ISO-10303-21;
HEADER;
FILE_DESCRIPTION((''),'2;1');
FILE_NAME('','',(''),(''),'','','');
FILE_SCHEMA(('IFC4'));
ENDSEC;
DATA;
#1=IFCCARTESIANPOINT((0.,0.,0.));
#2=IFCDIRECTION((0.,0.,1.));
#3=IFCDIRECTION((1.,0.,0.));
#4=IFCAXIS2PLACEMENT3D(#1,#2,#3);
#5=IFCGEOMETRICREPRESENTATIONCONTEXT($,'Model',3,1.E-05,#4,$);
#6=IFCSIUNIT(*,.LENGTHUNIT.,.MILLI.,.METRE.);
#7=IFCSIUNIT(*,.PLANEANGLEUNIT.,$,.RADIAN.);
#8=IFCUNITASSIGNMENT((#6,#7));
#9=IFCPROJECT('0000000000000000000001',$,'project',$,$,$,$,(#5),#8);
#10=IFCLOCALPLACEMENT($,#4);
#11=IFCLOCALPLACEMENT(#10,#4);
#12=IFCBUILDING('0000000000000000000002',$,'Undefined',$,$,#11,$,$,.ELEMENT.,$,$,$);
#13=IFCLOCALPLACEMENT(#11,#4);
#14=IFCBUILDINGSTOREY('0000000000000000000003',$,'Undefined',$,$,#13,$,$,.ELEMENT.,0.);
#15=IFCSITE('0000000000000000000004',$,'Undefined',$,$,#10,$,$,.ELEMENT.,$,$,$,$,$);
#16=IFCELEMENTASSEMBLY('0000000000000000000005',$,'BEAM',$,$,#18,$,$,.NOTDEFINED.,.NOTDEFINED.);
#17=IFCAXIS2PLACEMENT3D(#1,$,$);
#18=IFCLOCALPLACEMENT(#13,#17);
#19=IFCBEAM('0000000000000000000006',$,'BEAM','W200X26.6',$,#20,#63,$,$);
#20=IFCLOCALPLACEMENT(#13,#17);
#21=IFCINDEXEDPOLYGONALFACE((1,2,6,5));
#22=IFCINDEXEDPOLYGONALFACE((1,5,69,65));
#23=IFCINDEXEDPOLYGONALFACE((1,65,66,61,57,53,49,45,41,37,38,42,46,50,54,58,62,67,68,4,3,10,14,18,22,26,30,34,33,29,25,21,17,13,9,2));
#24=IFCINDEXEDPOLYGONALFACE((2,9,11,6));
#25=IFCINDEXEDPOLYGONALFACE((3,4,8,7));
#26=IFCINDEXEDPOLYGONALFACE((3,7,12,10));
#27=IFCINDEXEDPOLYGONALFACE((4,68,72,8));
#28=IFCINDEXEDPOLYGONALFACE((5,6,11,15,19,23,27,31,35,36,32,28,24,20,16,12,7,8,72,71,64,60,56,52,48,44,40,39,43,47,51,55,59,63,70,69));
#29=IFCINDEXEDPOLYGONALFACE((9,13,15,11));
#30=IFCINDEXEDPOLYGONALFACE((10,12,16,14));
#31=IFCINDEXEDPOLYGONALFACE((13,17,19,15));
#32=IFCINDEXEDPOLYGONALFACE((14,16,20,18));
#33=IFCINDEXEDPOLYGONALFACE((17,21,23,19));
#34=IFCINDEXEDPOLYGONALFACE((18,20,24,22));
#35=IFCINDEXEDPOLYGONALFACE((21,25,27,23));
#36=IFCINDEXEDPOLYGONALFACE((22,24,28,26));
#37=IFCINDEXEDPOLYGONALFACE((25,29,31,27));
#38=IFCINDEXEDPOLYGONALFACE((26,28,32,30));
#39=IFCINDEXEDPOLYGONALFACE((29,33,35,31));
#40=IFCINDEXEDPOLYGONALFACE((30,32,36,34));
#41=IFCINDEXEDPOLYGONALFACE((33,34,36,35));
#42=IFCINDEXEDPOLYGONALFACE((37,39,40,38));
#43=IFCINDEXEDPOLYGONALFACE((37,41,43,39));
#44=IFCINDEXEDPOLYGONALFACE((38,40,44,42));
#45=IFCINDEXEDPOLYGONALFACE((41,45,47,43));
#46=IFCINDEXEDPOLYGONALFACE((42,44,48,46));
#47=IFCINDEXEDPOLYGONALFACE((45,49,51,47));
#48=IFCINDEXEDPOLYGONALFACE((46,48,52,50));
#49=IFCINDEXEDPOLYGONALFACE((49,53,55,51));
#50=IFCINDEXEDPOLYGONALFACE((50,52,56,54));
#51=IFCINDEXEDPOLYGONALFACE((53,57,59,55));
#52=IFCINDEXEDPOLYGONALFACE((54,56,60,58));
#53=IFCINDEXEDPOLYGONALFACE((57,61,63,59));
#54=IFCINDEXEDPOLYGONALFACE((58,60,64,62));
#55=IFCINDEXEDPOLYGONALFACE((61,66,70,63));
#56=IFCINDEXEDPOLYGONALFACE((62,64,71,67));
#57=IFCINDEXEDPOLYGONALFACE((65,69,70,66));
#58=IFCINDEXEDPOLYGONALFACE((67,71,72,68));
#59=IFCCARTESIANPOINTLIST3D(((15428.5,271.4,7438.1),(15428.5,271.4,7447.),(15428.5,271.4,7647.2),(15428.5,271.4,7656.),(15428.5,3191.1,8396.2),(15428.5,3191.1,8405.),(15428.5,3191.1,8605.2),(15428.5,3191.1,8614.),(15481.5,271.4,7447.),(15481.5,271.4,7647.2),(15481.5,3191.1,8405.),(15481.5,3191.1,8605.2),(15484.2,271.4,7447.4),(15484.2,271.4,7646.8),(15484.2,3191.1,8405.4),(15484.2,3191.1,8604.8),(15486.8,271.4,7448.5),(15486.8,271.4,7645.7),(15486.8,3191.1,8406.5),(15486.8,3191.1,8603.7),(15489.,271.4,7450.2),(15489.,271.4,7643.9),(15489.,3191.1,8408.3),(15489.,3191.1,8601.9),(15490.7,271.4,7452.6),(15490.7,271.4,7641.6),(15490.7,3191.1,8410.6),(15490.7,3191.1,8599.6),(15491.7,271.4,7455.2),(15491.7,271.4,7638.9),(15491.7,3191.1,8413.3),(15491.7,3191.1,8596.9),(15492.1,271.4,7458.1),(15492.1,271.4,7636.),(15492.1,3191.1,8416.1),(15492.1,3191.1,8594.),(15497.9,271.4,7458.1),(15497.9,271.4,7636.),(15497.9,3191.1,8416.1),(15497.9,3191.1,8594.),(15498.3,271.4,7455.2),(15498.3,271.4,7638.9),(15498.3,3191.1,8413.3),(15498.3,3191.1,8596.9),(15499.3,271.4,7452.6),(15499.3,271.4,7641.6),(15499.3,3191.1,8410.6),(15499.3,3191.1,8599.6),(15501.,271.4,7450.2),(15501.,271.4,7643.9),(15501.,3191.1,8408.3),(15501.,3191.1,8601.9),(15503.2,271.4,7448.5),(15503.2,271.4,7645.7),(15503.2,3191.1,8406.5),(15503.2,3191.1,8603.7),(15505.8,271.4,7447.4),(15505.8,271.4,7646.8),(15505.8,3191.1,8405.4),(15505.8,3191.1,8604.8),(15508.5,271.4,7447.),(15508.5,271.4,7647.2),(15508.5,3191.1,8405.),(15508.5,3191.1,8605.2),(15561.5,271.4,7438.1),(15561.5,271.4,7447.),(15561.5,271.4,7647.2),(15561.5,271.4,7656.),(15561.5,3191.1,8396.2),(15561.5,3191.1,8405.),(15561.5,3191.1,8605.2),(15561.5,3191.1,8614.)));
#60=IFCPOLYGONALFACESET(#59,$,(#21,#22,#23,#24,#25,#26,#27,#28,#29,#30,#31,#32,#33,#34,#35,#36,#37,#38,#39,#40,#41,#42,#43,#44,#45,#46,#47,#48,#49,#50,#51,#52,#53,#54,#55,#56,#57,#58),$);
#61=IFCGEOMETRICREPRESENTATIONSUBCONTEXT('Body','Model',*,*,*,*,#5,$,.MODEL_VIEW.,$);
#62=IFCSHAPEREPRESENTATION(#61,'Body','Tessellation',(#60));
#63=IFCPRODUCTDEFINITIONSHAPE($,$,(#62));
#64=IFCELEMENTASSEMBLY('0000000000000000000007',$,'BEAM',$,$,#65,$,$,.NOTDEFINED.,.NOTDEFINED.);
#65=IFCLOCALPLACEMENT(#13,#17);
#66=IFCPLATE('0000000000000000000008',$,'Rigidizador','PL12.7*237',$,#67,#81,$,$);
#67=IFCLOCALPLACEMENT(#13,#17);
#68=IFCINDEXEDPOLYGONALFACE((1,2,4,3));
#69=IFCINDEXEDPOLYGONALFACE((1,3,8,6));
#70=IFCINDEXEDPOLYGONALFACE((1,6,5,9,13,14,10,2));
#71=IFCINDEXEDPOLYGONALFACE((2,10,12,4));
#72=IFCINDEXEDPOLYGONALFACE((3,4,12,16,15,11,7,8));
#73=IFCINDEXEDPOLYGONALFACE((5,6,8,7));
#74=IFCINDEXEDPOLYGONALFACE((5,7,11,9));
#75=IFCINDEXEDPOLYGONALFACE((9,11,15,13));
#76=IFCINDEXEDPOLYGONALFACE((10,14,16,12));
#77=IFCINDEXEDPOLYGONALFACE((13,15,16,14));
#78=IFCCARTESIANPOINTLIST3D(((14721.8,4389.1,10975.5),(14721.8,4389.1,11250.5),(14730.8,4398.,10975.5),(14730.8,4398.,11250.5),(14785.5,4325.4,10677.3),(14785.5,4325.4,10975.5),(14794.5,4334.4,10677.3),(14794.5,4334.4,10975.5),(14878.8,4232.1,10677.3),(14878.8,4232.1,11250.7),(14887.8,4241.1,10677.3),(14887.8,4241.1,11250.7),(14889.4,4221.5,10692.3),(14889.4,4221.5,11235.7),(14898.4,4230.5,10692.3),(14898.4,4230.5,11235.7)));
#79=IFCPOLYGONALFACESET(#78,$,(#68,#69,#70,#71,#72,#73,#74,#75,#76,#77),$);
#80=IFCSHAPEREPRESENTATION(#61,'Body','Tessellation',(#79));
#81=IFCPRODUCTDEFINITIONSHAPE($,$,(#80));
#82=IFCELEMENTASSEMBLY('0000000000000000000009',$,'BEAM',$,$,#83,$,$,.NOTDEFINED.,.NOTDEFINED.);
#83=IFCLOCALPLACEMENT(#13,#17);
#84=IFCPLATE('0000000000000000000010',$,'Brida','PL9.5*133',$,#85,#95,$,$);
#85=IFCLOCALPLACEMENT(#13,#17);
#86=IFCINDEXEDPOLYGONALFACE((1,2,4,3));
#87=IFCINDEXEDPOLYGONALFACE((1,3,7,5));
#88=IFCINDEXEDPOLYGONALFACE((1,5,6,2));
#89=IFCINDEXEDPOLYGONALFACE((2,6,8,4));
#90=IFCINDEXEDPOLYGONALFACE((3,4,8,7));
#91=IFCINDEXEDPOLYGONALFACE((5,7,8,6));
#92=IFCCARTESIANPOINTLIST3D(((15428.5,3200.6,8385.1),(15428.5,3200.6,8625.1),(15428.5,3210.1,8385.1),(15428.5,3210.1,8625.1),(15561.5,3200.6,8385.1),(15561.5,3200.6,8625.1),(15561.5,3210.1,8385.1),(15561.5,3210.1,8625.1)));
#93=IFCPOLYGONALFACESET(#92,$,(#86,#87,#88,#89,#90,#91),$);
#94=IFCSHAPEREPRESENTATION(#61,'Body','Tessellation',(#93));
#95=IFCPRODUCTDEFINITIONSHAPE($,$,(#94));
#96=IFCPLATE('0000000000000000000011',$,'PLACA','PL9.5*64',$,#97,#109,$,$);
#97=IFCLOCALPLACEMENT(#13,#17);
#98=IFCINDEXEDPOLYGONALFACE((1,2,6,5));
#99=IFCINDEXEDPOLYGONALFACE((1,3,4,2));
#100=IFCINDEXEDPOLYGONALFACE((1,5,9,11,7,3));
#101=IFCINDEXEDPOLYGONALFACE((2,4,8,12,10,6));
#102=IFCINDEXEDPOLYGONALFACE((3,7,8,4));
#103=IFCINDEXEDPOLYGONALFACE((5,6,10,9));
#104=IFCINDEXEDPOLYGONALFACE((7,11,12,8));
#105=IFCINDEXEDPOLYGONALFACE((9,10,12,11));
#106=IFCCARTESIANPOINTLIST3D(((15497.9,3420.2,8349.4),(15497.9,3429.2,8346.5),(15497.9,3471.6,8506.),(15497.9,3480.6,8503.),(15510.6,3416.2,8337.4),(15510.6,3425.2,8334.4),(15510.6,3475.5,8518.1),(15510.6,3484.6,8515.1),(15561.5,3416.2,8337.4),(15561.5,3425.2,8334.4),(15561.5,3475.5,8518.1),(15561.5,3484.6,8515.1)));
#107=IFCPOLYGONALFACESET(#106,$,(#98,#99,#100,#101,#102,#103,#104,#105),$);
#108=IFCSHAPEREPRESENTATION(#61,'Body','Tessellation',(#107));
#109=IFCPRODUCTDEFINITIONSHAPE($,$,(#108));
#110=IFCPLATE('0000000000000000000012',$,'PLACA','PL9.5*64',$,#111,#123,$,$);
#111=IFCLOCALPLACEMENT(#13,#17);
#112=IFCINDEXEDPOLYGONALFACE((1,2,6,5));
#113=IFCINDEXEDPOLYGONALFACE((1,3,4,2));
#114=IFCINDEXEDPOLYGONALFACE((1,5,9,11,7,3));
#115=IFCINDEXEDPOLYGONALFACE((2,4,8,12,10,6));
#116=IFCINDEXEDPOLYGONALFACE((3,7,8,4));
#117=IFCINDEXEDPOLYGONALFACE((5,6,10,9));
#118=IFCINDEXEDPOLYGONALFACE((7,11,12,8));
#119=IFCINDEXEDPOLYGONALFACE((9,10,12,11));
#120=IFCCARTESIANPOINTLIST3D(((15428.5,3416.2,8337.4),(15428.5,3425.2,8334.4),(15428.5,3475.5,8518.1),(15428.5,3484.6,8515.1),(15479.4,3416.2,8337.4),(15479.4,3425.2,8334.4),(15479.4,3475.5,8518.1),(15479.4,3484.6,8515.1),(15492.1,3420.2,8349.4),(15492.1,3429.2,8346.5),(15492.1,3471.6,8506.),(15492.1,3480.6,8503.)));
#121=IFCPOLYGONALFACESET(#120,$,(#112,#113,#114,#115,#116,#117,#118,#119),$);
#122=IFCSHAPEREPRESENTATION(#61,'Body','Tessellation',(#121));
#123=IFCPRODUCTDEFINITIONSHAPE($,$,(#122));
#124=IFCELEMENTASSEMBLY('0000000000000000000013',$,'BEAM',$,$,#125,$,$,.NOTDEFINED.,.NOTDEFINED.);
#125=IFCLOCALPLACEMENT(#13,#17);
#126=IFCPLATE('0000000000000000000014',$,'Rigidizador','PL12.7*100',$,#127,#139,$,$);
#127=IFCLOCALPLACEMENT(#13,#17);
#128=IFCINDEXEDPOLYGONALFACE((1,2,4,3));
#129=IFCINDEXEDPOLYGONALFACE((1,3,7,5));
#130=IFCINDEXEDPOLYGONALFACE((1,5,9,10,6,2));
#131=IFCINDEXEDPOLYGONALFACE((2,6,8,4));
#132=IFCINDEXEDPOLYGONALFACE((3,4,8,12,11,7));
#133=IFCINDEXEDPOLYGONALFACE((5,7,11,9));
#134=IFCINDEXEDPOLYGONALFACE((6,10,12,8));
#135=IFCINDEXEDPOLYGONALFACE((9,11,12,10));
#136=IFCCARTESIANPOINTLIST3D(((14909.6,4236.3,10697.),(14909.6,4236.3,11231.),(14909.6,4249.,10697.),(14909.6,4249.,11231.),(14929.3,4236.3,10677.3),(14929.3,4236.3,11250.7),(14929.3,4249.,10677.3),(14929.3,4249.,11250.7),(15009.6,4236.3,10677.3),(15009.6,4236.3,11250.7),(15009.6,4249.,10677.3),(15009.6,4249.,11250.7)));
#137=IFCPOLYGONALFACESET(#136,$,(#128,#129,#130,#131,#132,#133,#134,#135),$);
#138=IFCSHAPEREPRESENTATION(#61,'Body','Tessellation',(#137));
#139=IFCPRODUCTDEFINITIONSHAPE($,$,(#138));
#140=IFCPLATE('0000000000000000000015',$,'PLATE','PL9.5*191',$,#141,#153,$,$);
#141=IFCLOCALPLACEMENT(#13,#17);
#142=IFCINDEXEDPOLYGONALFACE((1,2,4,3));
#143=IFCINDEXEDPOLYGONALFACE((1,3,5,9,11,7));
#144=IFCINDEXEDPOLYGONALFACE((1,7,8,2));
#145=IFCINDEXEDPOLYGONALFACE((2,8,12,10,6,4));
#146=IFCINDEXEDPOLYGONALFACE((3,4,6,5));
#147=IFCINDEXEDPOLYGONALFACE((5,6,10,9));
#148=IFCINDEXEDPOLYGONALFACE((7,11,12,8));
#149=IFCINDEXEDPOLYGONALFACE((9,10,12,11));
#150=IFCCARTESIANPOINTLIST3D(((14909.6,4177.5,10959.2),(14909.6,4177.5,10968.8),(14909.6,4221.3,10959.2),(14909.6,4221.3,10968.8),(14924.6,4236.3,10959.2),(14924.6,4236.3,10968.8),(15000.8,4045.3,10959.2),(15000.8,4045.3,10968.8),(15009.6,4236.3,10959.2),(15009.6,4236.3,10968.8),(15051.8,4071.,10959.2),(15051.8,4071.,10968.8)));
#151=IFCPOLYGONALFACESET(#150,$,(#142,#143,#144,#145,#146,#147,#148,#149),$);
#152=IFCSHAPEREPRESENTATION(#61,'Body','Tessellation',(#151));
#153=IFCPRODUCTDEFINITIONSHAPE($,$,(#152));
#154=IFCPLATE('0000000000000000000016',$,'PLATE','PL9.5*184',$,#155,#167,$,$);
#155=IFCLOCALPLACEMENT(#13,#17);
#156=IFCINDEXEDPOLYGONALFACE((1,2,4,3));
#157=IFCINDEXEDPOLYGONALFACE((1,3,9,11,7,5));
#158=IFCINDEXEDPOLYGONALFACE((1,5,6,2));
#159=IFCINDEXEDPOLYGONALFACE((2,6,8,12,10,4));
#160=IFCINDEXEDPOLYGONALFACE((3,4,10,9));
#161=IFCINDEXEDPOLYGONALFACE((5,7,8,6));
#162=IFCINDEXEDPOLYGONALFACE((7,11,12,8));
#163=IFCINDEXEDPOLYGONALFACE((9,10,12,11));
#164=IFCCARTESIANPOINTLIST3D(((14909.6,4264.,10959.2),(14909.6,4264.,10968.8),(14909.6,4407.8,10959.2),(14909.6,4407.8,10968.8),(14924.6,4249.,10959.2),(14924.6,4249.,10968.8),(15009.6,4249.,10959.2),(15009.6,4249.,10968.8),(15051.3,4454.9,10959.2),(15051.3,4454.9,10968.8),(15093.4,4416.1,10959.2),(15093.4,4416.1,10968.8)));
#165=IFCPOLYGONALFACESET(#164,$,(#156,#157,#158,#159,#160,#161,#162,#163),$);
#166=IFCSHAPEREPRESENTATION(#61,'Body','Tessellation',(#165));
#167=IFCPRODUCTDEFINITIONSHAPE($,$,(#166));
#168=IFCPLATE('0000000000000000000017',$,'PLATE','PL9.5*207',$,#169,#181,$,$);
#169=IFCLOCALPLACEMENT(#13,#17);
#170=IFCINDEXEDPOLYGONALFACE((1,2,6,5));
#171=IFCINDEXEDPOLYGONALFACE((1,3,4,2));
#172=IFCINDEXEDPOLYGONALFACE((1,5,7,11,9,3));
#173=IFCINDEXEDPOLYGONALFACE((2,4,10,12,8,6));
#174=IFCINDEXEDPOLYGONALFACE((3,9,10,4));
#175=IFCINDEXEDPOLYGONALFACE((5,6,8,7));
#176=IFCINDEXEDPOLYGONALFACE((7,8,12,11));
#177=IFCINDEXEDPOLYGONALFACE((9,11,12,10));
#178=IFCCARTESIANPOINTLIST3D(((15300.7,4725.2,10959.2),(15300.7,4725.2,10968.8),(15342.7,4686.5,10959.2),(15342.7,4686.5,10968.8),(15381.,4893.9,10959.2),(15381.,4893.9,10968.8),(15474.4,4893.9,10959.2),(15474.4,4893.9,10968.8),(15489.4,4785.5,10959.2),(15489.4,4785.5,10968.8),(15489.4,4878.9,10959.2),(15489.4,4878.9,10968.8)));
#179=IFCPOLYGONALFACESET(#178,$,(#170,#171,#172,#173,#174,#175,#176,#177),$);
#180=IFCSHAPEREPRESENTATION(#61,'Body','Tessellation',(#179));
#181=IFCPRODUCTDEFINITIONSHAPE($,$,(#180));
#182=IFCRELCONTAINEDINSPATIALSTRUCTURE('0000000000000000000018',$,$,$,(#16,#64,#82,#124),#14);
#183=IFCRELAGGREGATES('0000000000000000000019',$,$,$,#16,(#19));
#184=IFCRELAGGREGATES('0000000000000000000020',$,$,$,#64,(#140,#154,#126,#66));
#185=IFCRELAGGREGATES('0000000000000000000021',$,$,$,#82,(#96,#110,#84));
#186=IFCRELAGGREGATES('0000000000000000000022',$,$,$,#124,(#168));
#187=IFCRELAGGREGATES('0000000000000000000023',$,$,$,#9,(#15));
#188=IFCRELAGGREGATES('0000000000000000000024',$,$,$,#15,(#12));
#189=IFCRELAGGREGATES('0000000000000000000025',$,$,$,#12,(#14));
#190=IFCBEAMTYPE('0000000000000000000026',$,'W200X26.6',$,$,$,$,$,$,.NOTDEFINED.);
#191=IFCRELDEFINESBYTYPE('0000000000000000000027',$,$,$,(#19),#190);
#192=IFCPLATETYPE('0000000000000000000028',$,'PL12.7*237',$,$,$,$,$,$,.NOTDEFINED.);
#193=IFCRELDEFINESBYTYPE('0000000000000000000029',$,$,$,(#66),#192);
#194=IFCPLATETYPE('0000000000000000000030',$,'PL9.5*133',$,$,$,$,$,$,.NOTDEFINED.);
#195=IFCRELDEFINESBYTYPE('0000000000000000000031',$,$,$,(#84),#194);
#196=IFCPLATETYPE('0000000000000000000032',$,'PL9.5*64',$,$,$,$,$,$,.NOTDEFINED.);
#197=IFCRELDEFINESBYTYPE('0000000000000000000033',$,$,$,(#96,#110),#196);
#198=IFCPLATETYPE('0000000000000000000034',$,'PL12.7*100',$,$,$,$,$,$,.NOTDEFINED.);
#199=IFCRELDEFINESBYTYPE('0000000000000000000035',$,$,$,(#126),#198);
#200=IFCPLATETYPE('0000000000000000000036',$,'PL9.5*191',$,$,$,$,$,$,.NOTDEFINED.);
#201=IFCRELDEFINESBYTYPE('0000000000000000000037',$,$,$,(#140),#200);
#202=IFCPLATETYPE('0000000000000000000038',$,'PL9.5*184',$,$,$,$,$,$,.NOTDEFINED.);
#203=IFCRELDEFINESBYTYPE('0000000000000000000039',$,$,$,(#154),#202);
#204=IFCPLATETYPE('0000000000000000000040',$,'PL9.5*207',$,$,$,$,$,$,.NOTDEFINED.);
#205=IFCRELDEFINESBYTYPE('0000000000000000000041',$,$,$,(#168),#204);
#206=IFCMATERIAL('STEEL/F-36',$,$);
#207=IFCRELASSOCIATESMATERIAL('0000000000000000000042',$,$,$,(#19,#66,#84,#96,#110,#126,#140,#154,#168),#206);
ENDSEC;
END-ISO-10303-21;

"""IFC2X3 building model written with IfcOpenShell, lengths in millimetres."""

from ifc_helpers import new_model, si_unit, frame, origin_with_axes, origin_2d_with_axis, place, context, subcontext, project, spatial, polyline, i_section, outline, extrude, clip, halfspace, material, type_object, element, aggregate, save


model = new_model("IFC2X3")

# Units and contexts
model_context = context("Model", 3, precision=1e-05, world=origin_with_axes())
body_context = subcontext(model_context, "Body", "Model", "MODEL_VIEW")
ifc_project = project(units=[si_unit("LENGTHUNIT", "METRE", prefix="MILLI"), si_unit("PLANEANGLEUNIT", "RADIAN")], contexts=[model_context])

# Site, building, storey
site_placement = place(None, origin_with_axes())
site = spatial("IfcSite", under=ifc_project, at=site_placement, Name="Undefined", CompositionType="ELEMENT")
building_placement = place(site_placement, origin_with_axes())
building = spatial("IfcBuilding", under=site, at=building_placement, Name="Undefined", CompositionType="ELEMENT")
storey_placement = place(building_placement, origin_with_axes())
storey = spatial("IfcBuildingStorey", under=building, at=storey_placement, Name="Undefined", CompositionType="ELEMENT", Elevation=0.0)

# Shared definitions
ifc_material_1 = material(Name="STEEL/F-36")

# Element assembly, beam
assembly_1_placement = place(storey_placement, origin_with_axes())
assembly_1 = element("IfcElementAssembly", 1, at=assembly_1_placement, inside=storey, Name="BEAM", AssemblyPlace="NOTDEFINED", PredefinedType="NOTDEFINED")
beam_type_1 = type_object("IfcBeamType", Name="W200X26.6", PredefinedType="NOTDEFINED")
beam_1_placement = place(assembly_1_placement, frame((15495.0, 3232.7, 8518.7), z_axis=(0.0, -0.311771, 0.950157), x_axis=(0.0, -0.950157, -0.311771)))
beam_1 = element("IfcBeam", 2, at=beam_1_placement, type_object=beam_type_1, material=ifc_material_1, Name="BEAM", Description="W200X26.6", context=body_context, shape_type="Clipping", body=[
    clip(clip(extrude(i_section(OverallWidth=133.0, OverallDepth=207.0, WebThickness=5.8, FlangeThickness=8.4, FilletRadius=10.6, at=origin_2d_with_axis()), frame((3367.9, 0.0, 0.0), z_axis=(-1.0, 0.0, 0.0), x_axis=(0.0, -1.0, 0.0)), (0.0, 0.0, 1.0), 3392.7), halfspace(frame((3082.6, 0.0, 103.8), z_axis=(-0.950157, 0.0, -0.311771), x_axis=(0.311771, 0.0, -0.950157)), True)), halfspace(frame((8.8, 0.0, 106.5), z_axis=(-0.950152, 0.0, -0.311787), x_axis=(0.0, -1.0, 0.0)), False)),
])
aggregate(assembly_1, [beam_1])

# Element assembly, plate
assembly_2_placement = place(storey_placement, origin_with_axes())
assembly_2 = element("IfcElementAssembly", 3, at=assembly_2_placement, inside=storey, Name="BEAM", AssemblyPlace="NOTDEFINED", PredefinedType="NOTDEFINED")
plate_type_1 = type_object("IfcPlateType", Name="PL12.7*237", PredefinedType="NOTDEFINED")
plate_1_placement = place(assembly_2_placement, frame((14726.3, 4393.6, 11250.5), z_axis=(0.707106, 0.707107, 0.0), x_axis=(0.707107, -0.707106, 0.000873)))
plate_1 = element("IfcPlate", 4, at=plate_1_placement, type_object=plate_type_1, material=ifc_material_1, Name="Rigidizador", Description="PL12.7*237", context=body_context, shape_type="SweptSolid", body=[
    extrude(outline(polyline([(0.0, 0.0), (222.0, 0.0), (237.0, 15.0), (236.5, 558.4), (221.5, 573.4), (89.5, 573.3), (89.8, 275.1), (-0.2, 275.0), (0.0, 0.0)])), frame((0.0, 0.0, -6.3), z_axis=(0.0, 0.0, 1.0), x_axis=(1.0, 0.0, 0.0)), (0.0, 0.0, 1.0), 12.7),
])

# Element assembly, plates
assembly_3_placement = place(storey_placement, origin_with_axes())
assembly_3 = element("IfcElementAssembly", 5, at=assembly_3_placement, inside=storey, Name="BEAM", AssemblyPlace="NOTDEFINED", PredefinedType="NOTDEFINED")
plate_type_2 = type_object("IfcPlateType", Name="PL9.5*133", PredefinedType="NOTDEFINED")
plate_2_placement = place(assembly_3_placement, frame((15495.0, 3205.4, 8625.1), z_axis=(0.0, 1.0, -0.000017), x_axis=(0.0, -0.000017, -1.0)))
plate_2 = element("IfcPlate", 6, at=plate_2_placement, type_object=plate_type_2, material=ifc_material_1, Name="Brida", Description="PL9.5*133", context=body_context, shape_type="SweptSolid", body=[
    extrude(outline(polyline([(0.0, -66.5), (0.0, 66.5), (240.0, 66.5), (240.0, -66.5), (0.0, -66.5)])), frame((0.0, 0.0, -4.8), z_axis=(0.0, 0.0, 1.0), x_axis=(1.0, 0.0, 0.0)), (0.0, 0.0, 1.0), 9.5),
])
plate_type_3 = type_object("IfcPlateType", Name="PL9.5*64", PredefinedType="NOTDEFINED")
plate_3_placement = place(assembly_3_placement, frame((15497.9, 3480.0, 8516.6), z_axis=(0.0, 0.950147, -0.311803), x_axis=(1.0, 0.0, 0.0)))
plate_3 = element("IfcPlate", 7, at=plate_3_placement, type_object=plate_type_3, material=ifc_material_1, Name="PLACA", Description="PL9.5*64", context=body_context, shape_type="SweptSolid", body=[
    extrude(outline(polyline([(0.0, 12.7), (12.7, 0.0), (63.6, 0.0), (63.6, 190.2), (12.7, 190.2), (0.0, 177.5), (0.0, 12.7)])), frame((0.0, 0.0, -4.8), z_axis=(0.0, 0.0, 1.0), x_axis=(1.0, 0.0, 0.0)), (0.0, 0.0, 1.0), 9.5),
])
plate_4_placement = place(assembly_3_placement, frame((15428.5, 3480.0, 8516.6), z_axis=(0.0, 0.950147, -0.311803), x_axis=(1.0, 0.0, 0.0)))
plate_4 = element("IfcPlate", 8, at=plate_4_placement, type_object=plate_type_3, material=ifc_material_1, Name="PLACA", Description="PL9.5*64", context=body_context, shape_type="SweptSolid", body=[
    extrude(outline(polyline([(0.0, 0.0), (50.9, 0.0), (63.6, 12.7), (63.6, 177.5), (50.9, 190.2), (0.0, 190.2), (0.0, 0.0)])), frame((0.0, 0.0, -4.8), z_axis=(0.0, 0.0, 1.0), x_axis=(1.0, 0.0, 0.0)), (0.0, 0.0, 1.0), 9.5),
])

# Element assembly
assembly_4_placement = place(storey_placement, origin_with_axes())
assembly_4 = element("IfcElementAssembly", 9, at=assembly_4_placement, inside=storey, Name="BEAM", AssemblyPlace="NOTDEFINED", PredefinedType="NOTDEFINED")

# Plates
plate_type_4 = type_object("IfcPlateType", Name="PL12.7*100", PredefinedType="NOTDEFINED")
plate_5_placement = place(assembly_2_placement, frame((14909.6, 4242.7, 10677.3), z_axis=(0.0, -1.0, 0.0), x_axis=(1.0, 0.0, 0.0)))
plate_5 = element("IfcPlate", 10, at=plate_5_placement, type_object=plate_type_4, material=ifc_material_1, Name="Rigidizador", Description="PL12.7*100", context=body_context, shape_type="SweptSolid", body=[
    extrude(outline(polyline([(0.0, 19.7), (19.7, 0.0), (100.0, 0.0), (100.0, 573.4), (19.7, 573.4), (0.0, 553.7), (0.0, 19.7)])), frame((0.0, 0.0, -6.3), z_axis=(0.0, 0.0, 1.0), x_axis=(1.0, 0.0, 0.0)), (0.0, 0.0, 1.0), 12.7),
])
plate_type_5 = type_object("IfcPlateType", Name="PL9.5*191", PredefinedType="NOTDEFINED")
plate_6_placement = place(assembly_2_placement, frame((15009.6, 4236.3, 10964.0), z_axis=(0.0, 0.0, 1.0), x_axis=(-1.0, 0.0, 0.0)))
plate_6 = element("IfcPlate", 11, at=plate_6_placement, type_object=plate_type_5, material=ifc_material_1, Name="PLATE", Description="PL9.5*191", context=body_context, shape_type="SweptSolid", body=[
    extrude(outline(polyline([(0.0, 0.0), (85.0, 0.0), (100.0, 15.0), (100.0, 58.8), (8.8, 191.1), (-42.1, 165.4), (0.0, 0.0)])), frame((0.0, 0.0, -4.8), z_axis=(0.0, 0.0, 1.0), x_axis=(1.0, 0.0, 0.0)), (0.0, 0.0, 1.0), 9.5),
])
plate_type_6 = type_object("IfcPlateType", Name="PL9.5*184", PredefinedType="NOTDEFINED")
plate_7_placement = place(assembly_2_placement, frame((15009.6, 4249.0, 10964.0), z_axis=(0.0, 0.0, -1.0), x_axis=(-1.0, 0.0, 0.0)))
plate_7 = element("IfcPlate", 12, at=plate_7_placement, type_object=plate_type_6, material=ifc_material_1, Name="PLATE", Description="PL9.5*184", context=body_context, shape_type="SweptSolid", body=[
    extrude(outline(polyline([(0.0, 0.0), (85.0, 0.0), (100.0, 15.0), (100.0, 158.8), (-41.7, 205.8), (-83.8, 167.1), (0.0, 0.0)])), frame((0.0, 0.0, -4.8), z_axis=(0.0, 0.0, 1.0), x_axis=(1.0, 0.0, 0.0)), (0.0, 0.0, 1.0), 9.5),
])
aggregate(assembly_2, [plate_6, plate_7, plate_5, plate_1])
plate_type_7 = type_object("IfcPlateType", Name="PL9.5*207", PredefinedType="NOTDEFINED")
plate_8_placement = place(assembly_4_placement, frame((15489.4, 4785.5, 10964.0), z_axis=(0.0, 0.0, 1.0), x_axis=(0.0, 1.0, 0.0)))
plate_8 = element("IfcPlate", 13, at=plate_8_placement, type_object=plate_type_7, material=ifc_material_1, Name="PLATE", Description="PL9.5*207", context=body_context, shape_type="SweptSolid", body=[
    extrude(outline(polyline([(0.0, 0.0), (93.4, 0.0), (108.4, 15.0), (108.4, 108.4), (-60.4, 188.7), (-99.1, 146.7), (0.0, 0.0)])), frame((0.0, 0.0, -4.8), z_axis=(0.0, 0.0, 1.0), x_axis=(1.0, 0.0, 0.0)), (0.0, 0.0, 1.0), 9.5),
])
aggregate(assembly_3, [plate_3, plate_4, plate_2])

aggregate(assembly_4, [plate_8])

save(model, "model.ifc")
